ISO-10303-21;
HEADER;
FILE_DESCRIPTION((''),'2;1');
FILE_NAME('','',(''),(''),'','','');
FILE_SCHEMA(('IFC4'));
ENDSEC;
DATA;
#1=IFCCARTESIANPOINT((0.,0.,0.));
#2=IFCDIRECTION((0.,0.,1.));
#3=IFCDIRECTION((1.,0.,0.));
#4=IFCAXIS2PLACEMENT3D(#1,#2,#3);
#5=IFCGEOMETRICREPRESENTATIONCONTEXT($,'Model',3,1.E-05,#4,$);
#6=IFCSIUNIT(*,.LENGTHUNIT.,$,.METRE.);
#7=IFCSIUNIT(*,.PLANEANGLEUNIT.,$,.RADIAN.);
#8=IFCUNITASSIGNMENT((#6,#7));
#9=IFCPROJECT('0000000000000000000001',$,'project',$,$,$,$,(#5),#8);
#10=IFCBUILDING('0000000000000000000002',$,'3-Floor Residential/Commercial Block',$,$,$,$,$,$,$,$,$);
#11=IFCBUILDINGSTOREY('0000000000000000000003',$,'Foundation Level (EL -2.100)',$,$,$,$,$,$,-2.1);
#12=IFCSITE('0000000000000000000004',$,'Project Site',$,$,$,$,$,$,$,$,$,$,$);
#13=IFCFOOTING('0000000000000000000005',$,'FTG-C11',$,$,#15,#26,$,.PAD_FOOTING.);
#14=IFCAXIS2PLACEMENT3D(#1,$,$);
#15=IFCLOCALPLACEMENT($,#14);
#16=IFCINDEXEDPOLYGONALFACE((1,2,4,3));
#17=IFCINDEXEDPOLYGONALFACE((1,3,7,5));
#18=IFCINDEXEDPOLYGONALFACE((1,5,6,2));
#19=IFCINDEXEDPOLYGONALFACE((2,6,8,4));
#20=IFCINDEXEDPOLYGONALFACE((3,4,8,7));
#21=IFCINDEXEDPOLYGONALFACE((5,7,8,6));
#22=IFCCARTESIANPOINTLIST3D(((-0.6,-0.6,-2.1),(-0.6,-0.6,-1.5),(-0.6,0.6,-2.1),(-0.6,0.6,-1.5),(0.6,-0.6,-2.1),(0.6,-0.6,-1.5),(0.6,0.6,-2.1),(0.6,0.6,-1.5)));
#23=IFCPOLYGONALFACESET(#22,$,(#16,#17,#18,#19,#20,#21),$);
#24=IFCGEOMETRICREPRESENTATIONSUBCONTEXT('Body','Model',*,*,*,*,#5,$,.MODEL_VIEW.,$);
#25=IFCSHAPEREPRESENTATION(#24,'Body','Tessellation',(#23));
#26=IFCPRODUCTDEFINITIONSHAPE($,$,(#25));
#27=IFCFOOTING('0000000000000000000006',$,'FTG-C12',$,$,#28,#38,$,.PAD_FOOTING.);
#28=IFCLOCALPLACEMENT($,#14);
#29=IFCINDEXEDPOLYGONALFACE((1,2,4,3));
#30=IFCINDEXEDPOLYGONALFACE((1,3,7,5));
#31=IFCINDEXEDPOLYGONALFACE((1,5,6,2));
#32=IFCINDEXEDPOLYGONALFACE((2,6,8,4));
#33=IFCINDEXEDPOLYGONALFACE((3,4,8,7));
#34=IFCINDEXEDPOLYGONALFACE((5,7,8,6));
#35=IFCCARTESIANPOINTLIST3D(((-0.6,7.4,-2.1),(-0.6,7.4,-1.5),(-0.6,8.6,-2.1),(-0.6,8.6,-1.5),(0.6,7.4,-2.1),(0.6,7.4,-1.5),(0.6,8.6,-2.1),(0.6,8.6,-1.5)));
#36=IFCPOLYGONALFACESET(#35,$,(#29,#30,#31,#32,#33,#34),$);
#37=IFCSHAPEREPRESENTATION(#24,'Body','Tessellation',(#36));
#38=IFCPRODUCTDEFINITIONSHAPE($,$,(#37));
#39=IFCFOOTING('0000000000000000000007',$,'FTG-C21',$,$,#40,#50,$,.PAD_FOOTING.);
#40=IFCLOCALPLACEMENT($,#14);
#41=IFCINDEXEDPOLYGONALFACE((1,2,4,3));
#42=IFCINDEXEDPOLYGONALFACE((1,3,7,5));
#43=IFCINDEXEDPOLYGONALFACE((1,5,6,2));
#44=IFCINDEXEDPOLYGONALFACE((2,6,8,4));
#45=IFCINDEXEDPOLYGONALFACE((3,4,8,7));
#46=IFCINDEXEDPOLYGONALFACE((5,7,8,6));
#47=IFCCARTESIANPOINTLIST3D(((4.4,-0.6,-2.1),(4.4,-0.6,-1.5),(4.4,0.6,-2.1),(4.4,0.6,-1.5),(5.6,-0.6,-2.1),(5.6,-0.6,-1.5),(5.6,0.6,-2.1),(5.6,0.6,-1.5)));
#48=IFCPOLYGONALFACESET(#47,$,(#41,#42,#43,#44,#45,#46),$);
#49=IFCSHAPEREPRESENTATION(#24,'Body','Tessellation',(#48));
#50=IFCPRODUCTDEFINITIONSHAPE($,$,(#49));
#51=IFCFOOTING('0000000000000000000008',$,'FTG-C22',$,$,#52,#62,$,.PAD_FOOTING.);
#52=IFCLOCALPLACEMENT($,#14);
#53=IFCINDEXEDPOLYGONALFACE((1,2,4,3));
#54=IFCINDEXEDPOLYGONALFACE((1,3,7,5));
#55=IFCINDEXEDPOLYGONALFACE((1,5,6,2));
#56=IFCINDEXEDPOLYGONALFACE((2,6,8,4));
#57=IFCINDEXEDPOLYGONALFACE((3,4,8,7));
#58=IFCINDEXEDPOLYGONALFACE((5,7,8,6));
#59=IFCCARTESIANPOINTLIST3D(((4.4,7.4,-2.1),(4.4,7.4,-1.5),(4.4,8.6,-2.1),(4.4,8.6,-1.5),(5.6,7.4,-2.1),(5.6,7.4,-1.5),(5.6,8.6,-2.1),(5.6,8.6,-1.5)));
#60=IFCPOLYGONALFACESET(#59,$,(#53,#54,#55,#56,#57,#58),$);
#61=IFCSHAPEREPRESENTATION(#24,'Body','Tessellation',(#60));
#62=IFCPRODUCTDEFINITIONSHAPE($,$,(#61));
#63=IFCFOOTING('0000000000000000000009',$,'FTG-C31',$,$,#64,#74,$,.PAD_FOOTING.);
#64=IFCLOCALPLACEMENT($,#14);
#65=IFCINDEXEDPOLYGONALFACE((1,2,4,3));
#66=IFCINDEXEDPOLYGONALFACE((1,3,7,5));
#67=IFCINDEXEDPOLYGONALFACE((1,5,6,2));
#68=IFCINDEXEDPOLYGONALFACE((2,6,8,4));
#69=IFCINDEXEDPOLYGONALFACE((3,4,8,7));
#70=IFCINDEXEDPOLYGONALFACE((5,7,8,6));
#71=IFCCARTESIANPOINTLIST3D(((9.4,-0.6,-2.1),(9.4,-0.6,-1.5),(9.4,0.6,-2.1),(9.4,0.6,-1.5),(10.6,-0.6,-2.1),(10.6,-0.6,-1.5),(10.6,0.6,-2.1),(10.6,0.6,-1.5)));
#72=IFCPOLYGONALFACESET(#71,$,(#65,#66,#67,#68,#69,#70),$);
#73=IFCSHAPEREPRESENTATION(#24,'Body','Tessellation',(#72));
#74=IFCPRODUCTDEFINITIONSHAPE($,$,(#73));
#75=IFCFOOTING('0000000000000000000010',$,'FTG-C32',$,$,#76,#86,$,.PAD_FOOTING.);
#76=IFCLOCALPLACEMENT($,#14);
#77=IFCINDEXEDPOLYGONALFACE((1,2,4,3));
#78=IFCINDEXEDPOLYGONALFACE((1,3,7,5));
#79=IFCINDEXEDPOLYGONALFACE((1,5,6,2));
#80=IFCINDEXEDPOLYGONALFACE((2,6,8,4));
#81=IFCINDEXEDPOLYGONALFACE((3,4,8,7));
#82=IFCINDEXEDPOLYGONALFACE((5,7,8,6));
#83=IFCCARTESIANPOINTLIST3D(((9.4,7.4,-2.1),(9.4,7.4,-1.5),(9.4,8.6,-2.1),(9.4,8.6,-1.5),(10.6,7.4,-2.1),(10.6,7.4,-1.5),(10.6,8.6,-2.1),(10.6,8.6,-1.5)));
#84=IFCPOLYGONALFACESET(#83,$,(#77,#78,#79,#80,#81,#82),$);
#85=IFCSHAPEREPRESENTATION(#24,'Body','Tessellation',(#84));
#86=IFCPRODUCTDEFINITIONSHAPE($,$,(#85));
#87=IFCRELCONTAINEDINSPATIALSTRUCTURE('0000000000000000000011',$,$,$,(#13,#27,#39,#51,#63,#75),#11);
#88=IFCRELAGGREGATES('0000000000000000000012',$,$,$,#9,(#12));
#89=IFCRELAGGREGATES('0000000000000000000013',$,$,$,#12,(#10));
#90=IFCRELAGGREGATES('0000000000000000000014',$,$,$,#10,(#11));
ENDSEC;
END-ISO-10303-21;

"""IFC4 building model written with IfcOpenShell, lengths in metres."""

from ifc_helpers import new_model, si_unit, frame, frame_2d, origin_with_axes, place, context, subcontext, project, spatial, rectangle, extrude, element, save


model = new_model("IFC4")

# Units and contexts
model_context = context("Model", 3, precision=1e-05, world=origin_with_axes())
body_context = subcontext(model_context, "Body", "Model", "MODEL_VIEW")
ifc_project = project(units=[si_unit("LENGTHUNIT", "METRE"), si_unit("PLANEANGLEUNIT", "RADIAN")], contexts=[model_context])

# Site, building, storey
site = spatial("IfcSite", under=ifc_project, Name="Project Site")
building = spatial("IfcBuilding", under=site, Name="3-Floor Residential/Commercial Block")
storey = spatial("IfcBuildingStorey", under=building, Name="Foundation Level (EL -2.100)", Elevation=-2.1)

# Footings
for number, where, z_axis, x_axis, name in (
    (1, (-0.6, -0.6, -2.1), (0.0, 0.0, 1.0), (1.0, 0.0, 0.0), "FTG-C11"),
    (2, (-0.6, 7.4, -2.1), (0.0, 0.0, 1.0), (1.0, 0.0, 0.0), "FTG-C12"),
    (3, (4.4, -0.6, -2.1), (0.0, 0.0, 1.0), (1.0, 0.0, 0.0), "FTG-C21"),
    (4, (4.4, 7.4, -2.1), (0.0, 0.0, 1.0), (1.0, 0.0, 0.0), "FTG-C22"),
    (5, (9.4, -0.6, -2.1), (0.0, 0.0, 1.0), (1.0, 0.0, 0.0), "FTG-C31"),
    (6, (9.4, 7.4, -2.1), (0.0, 0.0, 1.0), (1.0, 0.0, 0.0), "FTG-C32"),
):
    element("IfcFooting", number, at=place(None, frame(where, z_axis=z_axis, x_axis=x_axis)), inside=storey, Name=name, PredefinedType="PAD_FOOTING", context=body_context, shape_type="SweptSolid", body=[
        extrude(rectangle(XDim=1.2, YDim=1.2, at=frame_2d((0.6, 0.6))), origin_with_axes(), (0.0, 0.0, 1.0), 0.6),
    ])

save(model, "model.ifc")
